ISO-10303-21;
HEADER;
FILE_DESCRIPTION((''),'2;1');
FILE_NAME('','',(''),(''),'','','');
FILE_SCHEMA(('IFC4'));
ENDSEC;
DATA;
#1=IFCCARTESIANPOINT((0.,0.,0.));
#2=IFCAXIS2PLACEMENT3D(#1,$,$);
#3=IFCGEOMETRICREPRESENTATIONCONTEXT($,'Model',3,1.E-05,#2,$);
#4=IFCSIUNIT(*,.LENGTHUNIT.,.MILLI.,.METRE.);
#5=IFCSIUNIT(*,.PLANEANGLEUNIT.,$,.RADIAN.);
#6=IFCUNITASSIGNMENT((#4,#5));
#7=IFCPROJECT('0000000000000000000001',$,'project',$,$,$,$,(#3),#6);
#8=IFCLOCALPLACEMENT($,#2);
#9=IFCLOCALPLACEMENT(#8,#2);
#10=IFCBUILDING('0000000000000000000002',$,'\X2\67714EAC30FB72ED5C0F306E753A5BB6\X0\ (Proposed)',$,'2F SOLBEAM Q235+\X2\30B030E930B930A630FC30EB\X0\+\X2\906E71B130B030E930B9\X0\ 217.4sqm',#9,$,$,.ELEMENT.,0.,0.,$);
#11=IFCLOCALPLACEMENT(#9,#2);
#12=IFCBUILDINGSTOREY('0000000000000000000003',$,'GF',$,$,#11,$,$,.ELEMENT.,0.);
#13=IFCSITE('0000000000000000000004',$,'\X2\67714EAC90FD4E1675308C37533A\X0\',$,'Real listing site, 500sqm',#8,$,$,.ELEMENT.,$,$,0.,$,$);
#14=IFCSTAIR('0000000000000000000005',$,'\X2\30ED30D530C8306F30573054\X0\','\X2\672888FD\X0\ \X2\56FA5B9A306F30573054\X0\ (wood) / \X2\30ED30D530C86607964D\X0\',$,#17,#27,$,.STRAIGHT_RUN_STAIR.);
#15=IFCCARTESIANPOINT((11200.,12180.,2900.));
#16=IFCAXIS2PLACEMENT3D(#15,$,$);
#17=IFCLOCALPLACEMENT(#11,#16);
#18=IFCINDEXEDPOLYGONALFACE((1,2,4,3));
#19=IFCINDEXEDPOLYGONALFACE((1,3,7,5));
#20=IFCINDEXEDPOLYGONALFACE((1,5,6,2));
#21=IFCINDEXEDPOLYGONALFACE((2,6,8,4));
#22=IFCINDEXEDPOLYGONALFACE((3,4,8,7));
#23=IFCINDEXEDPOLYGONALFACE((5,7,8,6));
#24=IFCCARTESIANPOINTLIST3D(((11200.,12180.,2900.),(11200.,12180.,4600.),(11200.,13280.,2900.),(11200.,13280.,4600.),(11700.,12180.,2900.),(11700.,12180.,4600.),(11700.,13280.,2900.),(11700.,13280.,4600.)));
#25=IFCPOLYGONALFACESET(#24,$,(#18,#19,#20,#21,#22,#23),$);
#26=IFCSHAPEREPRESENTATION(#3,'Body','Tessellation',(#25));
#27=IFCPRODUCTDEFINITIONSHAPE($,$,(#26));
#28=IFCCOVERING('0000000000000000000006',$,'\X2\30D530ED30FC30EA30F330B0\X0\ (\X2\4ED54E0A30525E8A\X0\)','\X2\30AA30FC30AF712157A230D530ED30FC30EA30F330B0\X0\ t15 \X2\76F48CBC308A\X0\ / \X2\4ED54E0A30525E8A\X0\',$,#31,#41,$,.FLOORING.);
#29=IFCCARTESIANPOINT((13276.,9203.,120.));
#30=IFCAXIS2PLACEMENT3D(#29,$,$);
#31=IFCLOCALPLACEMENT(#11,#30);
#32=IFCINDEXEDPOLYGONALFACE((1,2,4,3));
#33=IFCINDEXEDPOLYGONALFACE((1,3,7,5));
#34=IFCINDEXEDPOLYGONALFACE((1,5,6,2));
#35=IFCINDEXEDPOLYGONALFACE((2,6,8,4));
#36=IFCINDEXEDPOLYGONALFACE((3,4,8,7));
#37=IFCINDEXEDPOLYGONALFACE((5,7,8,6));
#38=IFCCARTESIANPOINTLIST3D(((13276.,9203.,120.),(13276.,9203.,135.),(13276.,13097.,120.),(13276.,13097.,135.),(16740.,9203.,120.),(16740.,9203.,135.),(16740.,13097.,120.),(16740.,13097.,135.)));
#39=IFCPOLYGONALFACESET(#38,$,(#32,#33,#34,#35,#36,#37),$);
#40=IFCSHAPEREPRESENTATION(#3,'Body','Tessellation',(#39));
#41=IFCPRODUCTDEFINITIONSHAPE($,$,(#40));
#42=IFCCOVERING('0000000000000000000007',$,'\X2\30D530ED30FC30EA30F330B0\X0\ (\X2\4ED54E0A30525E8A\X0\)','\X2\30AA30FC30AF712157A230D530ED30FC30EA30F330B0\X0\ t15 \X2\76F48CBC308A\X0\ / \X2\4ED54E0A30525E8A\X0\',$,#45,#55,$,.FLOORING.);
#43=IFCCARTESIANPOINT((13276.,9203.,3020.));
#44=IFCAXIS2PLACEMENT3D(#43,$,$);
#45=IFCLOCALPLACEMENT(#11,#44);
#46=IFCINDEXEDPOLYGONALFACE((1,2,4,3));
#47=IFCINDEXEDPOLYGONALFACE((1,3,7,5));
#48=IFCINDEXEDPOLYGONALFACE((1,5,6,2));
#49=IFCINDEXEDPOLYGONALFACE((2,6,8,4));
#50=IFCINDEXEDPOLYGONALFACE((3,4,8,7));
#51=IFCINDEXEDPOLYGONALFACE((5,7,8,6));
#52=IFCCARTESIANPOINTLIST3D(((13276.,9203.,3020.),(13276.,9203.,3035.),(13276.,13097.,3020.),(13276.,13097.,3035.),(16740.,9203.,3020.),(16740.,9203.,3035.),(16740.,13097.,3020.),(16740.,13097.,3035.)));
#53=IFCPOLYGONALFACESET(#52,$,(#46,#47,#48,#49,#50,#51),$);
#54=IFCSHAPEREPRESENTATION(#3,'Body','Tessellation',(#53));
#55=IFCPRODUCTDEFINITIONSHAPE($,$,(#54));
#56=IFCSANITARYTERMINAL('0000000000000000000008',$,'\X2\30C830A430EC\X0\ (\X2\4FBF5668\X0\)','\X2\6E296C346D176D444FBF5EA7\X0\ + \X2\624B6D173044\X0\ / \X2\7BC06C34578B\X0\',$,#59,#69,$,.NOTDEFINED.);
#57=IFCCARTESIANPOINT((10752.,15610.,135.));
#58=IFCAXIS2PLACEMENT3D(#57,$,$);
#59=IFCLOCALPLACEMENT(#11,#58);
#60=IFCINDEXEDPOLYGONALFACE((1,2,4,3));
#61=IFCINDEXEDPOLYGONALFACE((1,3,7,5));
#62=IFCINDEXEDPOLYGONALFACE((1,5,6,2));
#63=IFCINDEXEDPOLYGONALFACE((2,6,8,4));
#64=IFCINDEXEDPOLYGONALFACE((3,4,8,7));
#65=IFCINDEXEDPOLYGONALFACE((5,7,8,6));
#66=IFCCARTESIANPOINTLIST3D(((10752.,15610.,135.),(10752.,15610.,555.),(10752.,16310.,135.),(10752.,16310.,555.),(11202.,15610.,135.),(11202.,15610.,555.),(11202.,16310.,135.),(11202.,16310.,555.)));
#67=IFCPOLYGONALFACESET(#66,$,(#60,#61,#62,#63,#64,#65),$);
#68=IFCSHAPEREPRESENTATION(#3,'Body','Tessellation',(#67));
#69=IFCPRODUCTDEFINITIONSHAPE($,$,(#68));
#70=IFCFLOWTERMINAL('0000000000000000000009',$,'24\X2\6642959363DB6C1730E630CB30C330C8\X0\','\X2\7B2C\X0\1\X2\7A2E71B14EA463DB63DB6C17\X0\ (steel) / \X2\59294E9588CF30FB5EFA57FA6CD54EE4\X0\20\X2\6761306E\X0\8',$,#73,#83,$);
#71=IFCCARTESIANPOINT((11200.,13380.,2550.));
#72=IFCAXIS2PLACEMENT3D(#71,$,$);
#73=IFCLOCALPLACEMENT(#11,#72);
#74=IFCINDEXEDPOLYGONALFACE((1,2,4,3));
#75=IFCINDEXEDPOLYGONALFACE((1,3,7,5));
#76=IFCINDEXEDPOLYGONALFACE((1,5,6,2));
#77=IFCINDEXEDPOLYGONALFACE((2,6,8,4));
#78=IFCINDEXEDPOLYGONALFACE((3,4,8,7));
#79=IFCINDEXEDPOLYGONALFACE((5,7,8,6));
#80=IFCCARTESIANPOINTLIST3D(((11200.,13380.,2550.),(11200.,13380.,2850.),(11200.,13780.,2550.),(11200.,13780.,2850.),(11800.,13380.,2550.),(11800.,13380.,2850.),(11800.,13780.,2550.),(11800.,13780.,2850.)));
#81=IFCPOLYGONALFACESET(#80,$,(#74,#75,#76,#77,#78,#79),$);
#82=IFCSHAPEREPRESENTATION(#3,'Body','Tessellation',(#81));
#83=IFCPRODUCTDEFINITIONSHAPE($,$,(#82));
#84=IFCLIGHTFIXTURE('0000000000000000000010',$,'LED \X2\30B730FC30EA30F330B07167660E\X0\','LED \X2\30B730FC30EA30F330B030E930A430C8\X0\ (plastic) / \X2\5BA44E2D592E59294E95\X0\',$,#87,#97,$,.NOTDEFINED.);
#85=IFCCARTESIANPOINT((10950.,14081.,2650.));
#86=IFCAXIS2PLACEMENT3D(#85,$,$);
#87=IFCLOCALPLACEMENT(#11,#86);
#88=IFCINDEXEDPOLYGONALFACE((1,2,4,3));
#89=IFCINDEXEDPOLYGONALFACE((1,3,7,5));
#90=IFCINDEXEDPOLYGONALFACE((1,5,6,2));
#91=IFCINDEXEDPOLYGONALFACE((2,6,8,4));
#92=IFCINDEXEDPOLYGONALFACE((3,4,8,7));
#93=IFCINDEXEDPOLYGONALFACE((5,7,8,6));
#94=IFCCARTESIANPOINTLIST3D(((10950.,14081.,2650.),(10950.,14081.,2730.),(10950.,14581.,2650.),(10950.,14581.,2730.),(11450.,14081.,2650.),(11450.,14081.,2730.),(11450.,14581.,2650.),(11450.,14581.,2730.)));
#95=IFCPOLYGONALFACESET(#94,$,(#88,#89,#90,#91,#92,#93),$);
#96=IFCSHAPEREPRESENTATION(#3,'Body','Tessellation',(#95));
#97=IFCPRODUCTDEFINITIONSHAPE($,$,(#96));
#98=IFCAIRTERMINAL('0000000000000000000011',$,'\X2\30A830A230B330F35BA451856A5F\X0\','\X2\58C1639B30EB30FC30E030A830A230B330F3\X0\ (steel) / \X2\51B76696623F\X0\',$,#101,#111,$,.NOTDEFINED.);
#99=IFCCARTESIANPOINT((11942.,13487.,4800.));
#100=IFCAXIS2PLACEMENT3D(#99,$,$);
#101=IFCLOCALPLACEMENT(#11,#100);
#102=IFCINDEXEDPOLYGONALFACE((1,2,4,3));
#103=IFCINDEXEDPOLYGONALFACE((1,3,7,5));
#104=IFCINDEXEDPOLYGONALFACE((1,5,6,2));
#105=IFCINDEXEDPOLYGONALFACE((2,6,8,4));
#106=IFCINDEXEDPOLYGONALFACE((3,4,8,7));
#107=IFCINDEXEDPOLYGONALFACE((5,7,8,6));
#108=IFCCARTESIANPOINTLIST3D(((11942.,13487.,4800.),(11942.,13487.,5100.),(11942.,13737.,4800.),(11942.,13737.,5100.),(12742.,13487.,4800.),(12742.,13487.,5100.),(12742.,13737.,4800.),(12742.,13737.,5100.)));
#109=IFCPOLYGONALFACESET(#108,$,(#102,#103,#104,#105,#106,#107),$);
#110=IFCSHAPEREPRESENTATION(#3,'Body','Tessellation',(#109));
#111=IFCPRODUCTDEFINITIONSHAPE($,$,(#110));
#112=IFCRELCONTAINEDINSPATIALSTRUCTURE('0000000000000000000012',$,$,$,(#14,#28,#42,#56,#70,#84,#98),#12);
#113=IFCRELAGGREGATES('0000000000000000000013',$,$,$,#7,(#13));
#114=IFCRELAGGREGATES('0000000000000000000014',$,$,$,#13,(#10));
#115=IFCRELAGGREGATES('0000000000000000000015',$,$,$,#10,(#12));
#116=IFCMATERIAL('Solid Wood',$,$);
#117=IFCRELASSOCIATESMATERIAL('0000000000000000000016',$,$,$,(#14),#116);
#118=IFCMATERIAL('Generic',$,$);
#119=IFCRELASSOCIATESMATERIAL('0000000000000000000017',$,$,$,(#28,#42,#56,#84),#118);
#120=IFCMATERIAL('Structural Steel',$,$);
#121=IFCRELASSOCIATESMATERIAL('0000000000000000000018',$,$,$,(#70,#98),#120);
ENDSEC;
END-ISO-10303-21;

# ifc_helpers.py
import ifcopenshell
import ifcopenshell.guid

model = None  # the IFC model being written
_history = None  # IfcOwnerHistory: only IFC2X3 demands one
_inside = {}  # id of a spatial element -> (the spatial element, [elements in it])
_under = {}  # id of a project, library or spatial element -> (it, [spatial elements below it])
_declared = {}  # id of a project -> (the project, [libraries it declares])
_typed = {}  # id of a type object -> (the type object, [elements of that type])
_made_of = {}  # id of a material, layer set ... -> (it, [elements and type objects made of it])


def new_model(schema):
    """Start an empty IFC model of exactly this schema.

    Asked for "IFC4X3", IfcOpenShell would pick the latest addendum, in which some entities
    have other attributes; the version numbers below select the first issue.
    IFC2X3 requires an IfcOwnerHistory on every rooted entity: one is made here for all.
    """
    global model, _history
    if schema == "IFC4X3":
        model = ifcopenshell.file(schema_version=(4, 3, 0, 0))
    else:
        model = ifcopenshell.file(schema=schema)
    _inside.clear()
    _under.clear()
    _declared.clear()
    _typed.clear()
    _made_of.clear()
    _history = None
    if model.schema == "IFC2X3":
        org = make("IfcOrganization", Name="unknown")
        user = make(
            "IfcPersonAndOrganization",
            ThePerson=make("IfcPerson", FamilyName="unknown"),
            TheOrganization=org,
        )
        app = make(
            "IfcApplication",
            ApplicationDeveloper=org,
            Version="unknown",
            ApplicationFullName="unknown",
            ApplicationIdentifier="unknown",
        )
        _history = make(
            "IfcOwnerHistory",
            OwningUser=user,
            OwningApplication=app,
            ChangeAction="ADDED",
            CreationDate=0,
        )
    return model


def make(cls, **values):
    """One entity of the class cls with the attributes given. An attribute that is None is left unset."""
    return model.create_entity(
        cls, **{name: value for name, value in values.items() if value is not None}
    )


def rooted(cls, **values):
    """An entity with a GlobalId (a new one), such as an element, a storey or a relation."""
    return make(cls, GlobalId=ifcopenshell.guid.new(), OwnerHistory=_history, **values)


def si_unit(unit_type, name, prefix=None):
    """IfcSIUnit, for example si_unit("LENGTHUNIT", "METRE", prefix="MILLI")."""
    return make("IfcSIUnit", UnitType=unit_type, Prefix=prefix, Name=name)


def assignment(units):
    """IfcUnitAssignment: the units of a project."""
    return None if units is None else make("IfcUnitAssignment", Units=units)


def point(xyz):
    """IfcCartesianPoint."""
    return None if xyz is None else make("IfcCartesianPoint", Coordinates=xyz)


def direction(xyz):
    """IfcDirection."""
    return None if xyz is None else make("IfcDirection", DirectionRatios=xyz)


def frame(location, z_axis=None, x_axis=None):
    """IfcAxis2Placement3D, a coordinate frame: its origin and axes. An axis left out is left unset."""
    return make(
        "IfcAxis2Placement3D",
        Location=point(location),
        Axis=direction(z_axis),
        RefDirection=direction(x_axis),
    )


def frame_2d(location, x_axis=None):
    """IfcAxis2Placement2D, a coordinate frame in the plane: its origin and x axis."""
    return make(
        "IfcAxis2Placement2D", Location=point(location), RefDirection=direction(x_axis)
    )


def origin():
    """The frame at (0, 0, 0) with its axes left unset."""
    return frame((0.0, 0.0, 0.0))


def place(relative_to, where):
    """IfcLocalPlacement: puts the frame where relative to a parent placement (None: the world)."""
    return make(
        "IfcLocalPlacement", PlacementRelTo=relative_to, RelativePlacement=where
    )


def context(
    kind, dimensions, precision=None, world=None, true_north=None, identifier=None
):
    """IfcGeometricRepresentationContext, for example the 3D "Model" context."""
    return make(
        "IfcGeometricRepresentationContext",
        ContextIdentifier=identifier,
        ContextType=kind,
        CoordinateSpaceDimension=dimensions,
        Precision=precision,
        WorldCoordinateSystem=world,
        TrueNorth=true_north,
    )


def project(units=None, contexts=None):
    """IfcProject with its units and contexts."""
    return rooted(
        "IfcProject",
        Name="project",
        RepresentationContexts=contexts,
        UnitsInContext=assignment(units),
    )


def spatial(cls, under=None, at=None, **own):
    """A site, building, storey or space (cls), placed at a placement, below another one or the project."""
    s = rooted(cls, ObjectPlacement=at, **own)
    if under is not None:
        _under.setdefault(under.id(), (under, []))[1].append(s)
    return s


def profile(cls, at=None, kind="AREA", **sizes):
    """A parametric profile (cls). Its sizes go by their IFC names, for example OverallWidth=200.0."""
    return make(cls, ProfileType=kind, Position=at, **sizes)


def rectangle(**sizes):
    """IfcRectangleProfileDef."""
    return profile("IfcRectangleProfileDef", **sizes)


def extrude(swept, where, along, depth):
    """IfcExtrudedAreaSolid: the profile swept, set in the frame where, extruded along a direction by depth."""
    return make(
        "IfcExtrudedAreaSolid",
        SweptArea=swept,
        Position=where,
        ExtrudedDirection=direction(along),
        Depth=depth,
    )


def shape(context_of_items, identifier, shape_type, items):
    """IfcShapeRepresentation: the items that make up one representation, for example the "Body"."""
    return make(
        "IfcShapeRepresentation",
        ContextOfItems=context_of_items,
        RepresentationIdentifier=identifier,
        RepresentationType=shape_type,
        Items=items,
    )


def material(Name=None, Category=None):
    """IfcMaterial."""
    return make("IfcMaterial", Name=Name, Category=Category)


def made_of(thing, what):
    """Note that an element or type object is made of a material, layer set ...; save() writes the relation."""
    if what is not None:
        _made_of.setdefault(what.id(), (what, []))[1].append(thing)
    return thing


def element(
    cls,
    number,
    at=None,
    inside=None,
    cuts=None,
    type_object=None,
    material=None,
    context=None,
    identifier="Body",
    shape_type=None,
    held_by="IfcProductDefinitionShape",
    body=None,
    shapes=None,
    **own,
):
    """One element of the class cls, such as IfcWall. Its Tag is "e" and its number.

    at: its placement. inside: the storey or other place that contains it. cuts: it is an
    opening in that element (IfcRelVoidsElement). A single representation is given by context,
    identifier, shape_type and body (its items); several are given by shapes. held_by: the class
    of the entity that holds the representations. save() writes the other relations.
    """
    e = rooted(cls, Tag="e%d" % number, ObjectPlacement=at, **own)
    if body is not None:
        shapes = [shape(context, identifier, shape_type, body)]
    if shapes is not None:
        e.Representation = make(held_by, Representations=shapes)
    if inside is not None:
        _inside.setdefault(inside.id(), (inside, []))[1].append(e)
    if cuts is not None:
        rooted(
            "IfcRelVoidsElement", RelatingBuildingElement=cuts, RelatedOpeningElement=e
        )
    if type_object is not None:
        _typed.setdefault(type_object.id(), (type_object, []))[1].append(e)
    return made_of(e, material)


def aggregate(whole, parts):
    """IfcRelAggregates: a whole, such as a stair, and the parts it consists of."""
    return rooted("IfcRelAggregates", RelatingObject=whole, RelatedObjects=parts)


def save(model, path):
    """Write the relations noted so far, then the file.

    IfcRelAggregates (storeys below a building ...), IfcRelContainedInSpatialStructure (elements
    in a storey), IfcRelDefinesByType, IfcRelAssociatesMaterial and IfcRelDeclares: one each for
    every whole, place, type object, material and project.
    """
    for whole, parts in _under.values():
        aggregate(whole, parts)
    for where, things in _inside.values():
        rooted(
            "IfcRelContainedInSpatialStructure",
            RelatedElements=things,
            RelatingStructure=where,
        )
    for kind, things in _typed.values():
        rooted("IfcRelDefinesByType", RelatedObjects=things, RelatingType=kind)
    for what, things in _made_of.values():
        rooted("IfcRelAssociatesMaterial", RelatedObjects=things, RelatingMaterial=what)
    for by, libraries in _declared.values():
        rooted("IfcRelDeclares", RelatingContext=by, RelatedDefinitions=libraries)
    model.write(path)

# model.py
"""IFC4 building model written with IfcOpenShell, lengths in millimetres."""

from ifc_helpers import new_model, si_unit, frame, frame_2d, origin, place, context, project, spatial, rectangle, extrude, material, element, save


model = new_model("IFC4")

# Units and contexts
model_context = context("Model", 3, precision=1e-05, world=origin())
ifc_project = project(units=[si_unit("LENGTHUNIT", "METRE", prefix="MILLI"), si_unit("PLANEANGLEUNIT", "RADIAN")], contexts=[model_context])

# Site, building, storey
site_placement = place(None, origin())
site = spatial("IfcSite", under=ifc_project, at=site_placement, Name="東京都世田谷区", ObjectType="Real listing site, 500sqm", CompositionType="ELEMENT", RefElevation=0.0)
building_placement = place(site_placement, origin())
building = spatial("IfcBuilding", under=site, at=building_placement, Name="東京・狭小の町家 (Proposed)", ObjectType="2F SOLBEAM Q235+グラスウール+遮熱グラス 217.4sqm", CompositionType="ELEMENT", ElevationOfRefHeight=0.0, ElevationOfTerrain=0.0)
storey_placement = place(building_placement, origin())
storey = spatial("IfcBuildingStorey", under=building, at=storey_placement, Name="GF", CompositionType="ELEMENT", Elevation=0.0)

# Shared definitions
ifc_material_1 = material(Name="Solid Wood")

# Stair
stair_placement = place(storey_placement, frame((11200.0, 12180.0, 2900.0)))
element("IfcStair", 1, at=stair_placement, inside=storey, material=ifc_material_1, Name="ロフトはしご", Description="木製 固定はしご (wood) / ロフト昇降", PredefinedType="STRAIGHT_RUN_STAIR", context=model_context, shape_type="SweptSolid", body=[
    extrude(rectangle(XDim=500.0, YDim=1100.0, at=frame_2d((250.0, 550.0))), frame((11200.0, 12180.0, 2900.0)), (0.0, 0.0, 1.0), 1700.0),
])

# Coverings
ifc_material_2 = material(Name="Generic")
covering_1_placement = place(storey_placement, frame((13276.0, 9203.0, 120.0)))
element("IfcCovering", 2, at=covering_1_placement, inside=storey, material=ifc_material_2, Name="フローリング (仕上げ床)", Description="オーク無垢フローリング t15 直貼り / 仕上げ床", PredefinedType="FLOORING", context=model_context, shape_type="SweptSolid", body=[
    extrude(rectangle(XDim=3464.0, YDim=3894.0, at=frame_2d((1732.0, 1947.0))), frame((13276.0, 9203.0, 120.0)), (0.0, 0.0, 1.0), 15.0),
])
covering_2_placement = place(storey_placement, frame((13276.0, 9203.0, 3020.0)))
element("IfcCovering", 3, at=covering_2_placement, inside=storey, material=ifc_material_2, Name="フローリング (仕上げ床)", Description="オーク無垢フローリング t15 直貼り / 仕上げ床", PredefinedType="FLOORING", context=model_context, shape_type="SweptSolid", body=[
    extrude(rectangle(XDim=3464.0, YDim=3894.0, at=frame_2d((1732.0, 1947.0))), frame((13276.0, 9203.0, 3020.0)), (0.0, 0.0, 1.0), 15.0),
])

# Sanitary terminal
sanitary_terminal_placement = place(storey_placement, frame((10752.0, 15610.0, 135.0)))
element("IfcSanitaryTerminal", 4, at=sanitary_terminal_placement, inside=storey, material=ifc_material_2, Name="トイレ (便器)", Description="温水洗浄便座 + 手洗い / 節水型", PredefinedType="NOTDEFINED", context=model_context, shape_type="SweptSolid", body=[
    extrude(rectangle(XDim=450.0, YDim=700.0, at=frame_2d((225.0, 350.0))), frame((10752.0, 15610.0, 135.0)), (0.0, 0.0, 1.0), 420.0),
])

# Flow terminal
ifc_material_3 = material(Name="Structural Steel")
flow_terminal_placement = place(storey_placement, frame((11200.0, 13380.0, 2550.0)))
element("IfcFlowTerminal", 5, at=flow_terminal_placement, inside=storey, material=ifc_material_3, Name="24時間換気ユニット", Description="第1種熱交換換気 (steel) / 天井裏・建基法令20条の8", context=model_context, shape_type="SweptSolid", body=[
    extrude(rectangle(XDim=600.0, YDim=400.0, at=frame_2d((300.0, 200.0))), frame((11200.0, 13380.0, 2550.0)), (0.0, 0.0, 1.0), 300.0),
])

# Light fixture
light_fixture_placement = place(storey_placement, frame((10950.0, 14081.0, 2650.0)))
element("IfcLightFixture", 6, at=light_fixture_placement, inside=storey, material=ifc_material_2, Name="LED シーリング照明", Description="LED シーリングライト (plastic) / 室中央天井", PredefinedType="NOTDEFINED", context=model_context, shape_type="SweptSolid", body=[
    extrude(rectangle(XDim=500.0, YDim=500.0, at=frame_2d((250.0, 250.0))), frame((10950.0, 14081.0, 2650.0)), (0.0, 0.0, 1.0), 80.0),
])

# Air terminal
air_terminal_placement = place(storey_placement, frame((11942.0, 13487.0, 4800.0)))
element("IfcAirTerminal", 7, at=air_terminal_placement, inside=storey, material=ifc_material_3, Name="エアコン室内機", Description="壁掛ルームエアコン (steel) / 冷暖房", PredefinedType="NOTDEFINED", context=model_context, shape_type="SweptSolid", body=[
    extrude(rectangle(XDim=800.0, YDim=250.0, at=frame_2d((400.0, 125.0))), frame((11942.0, 13487.0, 4800.0)), (0.0, 0.0, 1.0), 300.0),
])

save(model, "model.ifc")
